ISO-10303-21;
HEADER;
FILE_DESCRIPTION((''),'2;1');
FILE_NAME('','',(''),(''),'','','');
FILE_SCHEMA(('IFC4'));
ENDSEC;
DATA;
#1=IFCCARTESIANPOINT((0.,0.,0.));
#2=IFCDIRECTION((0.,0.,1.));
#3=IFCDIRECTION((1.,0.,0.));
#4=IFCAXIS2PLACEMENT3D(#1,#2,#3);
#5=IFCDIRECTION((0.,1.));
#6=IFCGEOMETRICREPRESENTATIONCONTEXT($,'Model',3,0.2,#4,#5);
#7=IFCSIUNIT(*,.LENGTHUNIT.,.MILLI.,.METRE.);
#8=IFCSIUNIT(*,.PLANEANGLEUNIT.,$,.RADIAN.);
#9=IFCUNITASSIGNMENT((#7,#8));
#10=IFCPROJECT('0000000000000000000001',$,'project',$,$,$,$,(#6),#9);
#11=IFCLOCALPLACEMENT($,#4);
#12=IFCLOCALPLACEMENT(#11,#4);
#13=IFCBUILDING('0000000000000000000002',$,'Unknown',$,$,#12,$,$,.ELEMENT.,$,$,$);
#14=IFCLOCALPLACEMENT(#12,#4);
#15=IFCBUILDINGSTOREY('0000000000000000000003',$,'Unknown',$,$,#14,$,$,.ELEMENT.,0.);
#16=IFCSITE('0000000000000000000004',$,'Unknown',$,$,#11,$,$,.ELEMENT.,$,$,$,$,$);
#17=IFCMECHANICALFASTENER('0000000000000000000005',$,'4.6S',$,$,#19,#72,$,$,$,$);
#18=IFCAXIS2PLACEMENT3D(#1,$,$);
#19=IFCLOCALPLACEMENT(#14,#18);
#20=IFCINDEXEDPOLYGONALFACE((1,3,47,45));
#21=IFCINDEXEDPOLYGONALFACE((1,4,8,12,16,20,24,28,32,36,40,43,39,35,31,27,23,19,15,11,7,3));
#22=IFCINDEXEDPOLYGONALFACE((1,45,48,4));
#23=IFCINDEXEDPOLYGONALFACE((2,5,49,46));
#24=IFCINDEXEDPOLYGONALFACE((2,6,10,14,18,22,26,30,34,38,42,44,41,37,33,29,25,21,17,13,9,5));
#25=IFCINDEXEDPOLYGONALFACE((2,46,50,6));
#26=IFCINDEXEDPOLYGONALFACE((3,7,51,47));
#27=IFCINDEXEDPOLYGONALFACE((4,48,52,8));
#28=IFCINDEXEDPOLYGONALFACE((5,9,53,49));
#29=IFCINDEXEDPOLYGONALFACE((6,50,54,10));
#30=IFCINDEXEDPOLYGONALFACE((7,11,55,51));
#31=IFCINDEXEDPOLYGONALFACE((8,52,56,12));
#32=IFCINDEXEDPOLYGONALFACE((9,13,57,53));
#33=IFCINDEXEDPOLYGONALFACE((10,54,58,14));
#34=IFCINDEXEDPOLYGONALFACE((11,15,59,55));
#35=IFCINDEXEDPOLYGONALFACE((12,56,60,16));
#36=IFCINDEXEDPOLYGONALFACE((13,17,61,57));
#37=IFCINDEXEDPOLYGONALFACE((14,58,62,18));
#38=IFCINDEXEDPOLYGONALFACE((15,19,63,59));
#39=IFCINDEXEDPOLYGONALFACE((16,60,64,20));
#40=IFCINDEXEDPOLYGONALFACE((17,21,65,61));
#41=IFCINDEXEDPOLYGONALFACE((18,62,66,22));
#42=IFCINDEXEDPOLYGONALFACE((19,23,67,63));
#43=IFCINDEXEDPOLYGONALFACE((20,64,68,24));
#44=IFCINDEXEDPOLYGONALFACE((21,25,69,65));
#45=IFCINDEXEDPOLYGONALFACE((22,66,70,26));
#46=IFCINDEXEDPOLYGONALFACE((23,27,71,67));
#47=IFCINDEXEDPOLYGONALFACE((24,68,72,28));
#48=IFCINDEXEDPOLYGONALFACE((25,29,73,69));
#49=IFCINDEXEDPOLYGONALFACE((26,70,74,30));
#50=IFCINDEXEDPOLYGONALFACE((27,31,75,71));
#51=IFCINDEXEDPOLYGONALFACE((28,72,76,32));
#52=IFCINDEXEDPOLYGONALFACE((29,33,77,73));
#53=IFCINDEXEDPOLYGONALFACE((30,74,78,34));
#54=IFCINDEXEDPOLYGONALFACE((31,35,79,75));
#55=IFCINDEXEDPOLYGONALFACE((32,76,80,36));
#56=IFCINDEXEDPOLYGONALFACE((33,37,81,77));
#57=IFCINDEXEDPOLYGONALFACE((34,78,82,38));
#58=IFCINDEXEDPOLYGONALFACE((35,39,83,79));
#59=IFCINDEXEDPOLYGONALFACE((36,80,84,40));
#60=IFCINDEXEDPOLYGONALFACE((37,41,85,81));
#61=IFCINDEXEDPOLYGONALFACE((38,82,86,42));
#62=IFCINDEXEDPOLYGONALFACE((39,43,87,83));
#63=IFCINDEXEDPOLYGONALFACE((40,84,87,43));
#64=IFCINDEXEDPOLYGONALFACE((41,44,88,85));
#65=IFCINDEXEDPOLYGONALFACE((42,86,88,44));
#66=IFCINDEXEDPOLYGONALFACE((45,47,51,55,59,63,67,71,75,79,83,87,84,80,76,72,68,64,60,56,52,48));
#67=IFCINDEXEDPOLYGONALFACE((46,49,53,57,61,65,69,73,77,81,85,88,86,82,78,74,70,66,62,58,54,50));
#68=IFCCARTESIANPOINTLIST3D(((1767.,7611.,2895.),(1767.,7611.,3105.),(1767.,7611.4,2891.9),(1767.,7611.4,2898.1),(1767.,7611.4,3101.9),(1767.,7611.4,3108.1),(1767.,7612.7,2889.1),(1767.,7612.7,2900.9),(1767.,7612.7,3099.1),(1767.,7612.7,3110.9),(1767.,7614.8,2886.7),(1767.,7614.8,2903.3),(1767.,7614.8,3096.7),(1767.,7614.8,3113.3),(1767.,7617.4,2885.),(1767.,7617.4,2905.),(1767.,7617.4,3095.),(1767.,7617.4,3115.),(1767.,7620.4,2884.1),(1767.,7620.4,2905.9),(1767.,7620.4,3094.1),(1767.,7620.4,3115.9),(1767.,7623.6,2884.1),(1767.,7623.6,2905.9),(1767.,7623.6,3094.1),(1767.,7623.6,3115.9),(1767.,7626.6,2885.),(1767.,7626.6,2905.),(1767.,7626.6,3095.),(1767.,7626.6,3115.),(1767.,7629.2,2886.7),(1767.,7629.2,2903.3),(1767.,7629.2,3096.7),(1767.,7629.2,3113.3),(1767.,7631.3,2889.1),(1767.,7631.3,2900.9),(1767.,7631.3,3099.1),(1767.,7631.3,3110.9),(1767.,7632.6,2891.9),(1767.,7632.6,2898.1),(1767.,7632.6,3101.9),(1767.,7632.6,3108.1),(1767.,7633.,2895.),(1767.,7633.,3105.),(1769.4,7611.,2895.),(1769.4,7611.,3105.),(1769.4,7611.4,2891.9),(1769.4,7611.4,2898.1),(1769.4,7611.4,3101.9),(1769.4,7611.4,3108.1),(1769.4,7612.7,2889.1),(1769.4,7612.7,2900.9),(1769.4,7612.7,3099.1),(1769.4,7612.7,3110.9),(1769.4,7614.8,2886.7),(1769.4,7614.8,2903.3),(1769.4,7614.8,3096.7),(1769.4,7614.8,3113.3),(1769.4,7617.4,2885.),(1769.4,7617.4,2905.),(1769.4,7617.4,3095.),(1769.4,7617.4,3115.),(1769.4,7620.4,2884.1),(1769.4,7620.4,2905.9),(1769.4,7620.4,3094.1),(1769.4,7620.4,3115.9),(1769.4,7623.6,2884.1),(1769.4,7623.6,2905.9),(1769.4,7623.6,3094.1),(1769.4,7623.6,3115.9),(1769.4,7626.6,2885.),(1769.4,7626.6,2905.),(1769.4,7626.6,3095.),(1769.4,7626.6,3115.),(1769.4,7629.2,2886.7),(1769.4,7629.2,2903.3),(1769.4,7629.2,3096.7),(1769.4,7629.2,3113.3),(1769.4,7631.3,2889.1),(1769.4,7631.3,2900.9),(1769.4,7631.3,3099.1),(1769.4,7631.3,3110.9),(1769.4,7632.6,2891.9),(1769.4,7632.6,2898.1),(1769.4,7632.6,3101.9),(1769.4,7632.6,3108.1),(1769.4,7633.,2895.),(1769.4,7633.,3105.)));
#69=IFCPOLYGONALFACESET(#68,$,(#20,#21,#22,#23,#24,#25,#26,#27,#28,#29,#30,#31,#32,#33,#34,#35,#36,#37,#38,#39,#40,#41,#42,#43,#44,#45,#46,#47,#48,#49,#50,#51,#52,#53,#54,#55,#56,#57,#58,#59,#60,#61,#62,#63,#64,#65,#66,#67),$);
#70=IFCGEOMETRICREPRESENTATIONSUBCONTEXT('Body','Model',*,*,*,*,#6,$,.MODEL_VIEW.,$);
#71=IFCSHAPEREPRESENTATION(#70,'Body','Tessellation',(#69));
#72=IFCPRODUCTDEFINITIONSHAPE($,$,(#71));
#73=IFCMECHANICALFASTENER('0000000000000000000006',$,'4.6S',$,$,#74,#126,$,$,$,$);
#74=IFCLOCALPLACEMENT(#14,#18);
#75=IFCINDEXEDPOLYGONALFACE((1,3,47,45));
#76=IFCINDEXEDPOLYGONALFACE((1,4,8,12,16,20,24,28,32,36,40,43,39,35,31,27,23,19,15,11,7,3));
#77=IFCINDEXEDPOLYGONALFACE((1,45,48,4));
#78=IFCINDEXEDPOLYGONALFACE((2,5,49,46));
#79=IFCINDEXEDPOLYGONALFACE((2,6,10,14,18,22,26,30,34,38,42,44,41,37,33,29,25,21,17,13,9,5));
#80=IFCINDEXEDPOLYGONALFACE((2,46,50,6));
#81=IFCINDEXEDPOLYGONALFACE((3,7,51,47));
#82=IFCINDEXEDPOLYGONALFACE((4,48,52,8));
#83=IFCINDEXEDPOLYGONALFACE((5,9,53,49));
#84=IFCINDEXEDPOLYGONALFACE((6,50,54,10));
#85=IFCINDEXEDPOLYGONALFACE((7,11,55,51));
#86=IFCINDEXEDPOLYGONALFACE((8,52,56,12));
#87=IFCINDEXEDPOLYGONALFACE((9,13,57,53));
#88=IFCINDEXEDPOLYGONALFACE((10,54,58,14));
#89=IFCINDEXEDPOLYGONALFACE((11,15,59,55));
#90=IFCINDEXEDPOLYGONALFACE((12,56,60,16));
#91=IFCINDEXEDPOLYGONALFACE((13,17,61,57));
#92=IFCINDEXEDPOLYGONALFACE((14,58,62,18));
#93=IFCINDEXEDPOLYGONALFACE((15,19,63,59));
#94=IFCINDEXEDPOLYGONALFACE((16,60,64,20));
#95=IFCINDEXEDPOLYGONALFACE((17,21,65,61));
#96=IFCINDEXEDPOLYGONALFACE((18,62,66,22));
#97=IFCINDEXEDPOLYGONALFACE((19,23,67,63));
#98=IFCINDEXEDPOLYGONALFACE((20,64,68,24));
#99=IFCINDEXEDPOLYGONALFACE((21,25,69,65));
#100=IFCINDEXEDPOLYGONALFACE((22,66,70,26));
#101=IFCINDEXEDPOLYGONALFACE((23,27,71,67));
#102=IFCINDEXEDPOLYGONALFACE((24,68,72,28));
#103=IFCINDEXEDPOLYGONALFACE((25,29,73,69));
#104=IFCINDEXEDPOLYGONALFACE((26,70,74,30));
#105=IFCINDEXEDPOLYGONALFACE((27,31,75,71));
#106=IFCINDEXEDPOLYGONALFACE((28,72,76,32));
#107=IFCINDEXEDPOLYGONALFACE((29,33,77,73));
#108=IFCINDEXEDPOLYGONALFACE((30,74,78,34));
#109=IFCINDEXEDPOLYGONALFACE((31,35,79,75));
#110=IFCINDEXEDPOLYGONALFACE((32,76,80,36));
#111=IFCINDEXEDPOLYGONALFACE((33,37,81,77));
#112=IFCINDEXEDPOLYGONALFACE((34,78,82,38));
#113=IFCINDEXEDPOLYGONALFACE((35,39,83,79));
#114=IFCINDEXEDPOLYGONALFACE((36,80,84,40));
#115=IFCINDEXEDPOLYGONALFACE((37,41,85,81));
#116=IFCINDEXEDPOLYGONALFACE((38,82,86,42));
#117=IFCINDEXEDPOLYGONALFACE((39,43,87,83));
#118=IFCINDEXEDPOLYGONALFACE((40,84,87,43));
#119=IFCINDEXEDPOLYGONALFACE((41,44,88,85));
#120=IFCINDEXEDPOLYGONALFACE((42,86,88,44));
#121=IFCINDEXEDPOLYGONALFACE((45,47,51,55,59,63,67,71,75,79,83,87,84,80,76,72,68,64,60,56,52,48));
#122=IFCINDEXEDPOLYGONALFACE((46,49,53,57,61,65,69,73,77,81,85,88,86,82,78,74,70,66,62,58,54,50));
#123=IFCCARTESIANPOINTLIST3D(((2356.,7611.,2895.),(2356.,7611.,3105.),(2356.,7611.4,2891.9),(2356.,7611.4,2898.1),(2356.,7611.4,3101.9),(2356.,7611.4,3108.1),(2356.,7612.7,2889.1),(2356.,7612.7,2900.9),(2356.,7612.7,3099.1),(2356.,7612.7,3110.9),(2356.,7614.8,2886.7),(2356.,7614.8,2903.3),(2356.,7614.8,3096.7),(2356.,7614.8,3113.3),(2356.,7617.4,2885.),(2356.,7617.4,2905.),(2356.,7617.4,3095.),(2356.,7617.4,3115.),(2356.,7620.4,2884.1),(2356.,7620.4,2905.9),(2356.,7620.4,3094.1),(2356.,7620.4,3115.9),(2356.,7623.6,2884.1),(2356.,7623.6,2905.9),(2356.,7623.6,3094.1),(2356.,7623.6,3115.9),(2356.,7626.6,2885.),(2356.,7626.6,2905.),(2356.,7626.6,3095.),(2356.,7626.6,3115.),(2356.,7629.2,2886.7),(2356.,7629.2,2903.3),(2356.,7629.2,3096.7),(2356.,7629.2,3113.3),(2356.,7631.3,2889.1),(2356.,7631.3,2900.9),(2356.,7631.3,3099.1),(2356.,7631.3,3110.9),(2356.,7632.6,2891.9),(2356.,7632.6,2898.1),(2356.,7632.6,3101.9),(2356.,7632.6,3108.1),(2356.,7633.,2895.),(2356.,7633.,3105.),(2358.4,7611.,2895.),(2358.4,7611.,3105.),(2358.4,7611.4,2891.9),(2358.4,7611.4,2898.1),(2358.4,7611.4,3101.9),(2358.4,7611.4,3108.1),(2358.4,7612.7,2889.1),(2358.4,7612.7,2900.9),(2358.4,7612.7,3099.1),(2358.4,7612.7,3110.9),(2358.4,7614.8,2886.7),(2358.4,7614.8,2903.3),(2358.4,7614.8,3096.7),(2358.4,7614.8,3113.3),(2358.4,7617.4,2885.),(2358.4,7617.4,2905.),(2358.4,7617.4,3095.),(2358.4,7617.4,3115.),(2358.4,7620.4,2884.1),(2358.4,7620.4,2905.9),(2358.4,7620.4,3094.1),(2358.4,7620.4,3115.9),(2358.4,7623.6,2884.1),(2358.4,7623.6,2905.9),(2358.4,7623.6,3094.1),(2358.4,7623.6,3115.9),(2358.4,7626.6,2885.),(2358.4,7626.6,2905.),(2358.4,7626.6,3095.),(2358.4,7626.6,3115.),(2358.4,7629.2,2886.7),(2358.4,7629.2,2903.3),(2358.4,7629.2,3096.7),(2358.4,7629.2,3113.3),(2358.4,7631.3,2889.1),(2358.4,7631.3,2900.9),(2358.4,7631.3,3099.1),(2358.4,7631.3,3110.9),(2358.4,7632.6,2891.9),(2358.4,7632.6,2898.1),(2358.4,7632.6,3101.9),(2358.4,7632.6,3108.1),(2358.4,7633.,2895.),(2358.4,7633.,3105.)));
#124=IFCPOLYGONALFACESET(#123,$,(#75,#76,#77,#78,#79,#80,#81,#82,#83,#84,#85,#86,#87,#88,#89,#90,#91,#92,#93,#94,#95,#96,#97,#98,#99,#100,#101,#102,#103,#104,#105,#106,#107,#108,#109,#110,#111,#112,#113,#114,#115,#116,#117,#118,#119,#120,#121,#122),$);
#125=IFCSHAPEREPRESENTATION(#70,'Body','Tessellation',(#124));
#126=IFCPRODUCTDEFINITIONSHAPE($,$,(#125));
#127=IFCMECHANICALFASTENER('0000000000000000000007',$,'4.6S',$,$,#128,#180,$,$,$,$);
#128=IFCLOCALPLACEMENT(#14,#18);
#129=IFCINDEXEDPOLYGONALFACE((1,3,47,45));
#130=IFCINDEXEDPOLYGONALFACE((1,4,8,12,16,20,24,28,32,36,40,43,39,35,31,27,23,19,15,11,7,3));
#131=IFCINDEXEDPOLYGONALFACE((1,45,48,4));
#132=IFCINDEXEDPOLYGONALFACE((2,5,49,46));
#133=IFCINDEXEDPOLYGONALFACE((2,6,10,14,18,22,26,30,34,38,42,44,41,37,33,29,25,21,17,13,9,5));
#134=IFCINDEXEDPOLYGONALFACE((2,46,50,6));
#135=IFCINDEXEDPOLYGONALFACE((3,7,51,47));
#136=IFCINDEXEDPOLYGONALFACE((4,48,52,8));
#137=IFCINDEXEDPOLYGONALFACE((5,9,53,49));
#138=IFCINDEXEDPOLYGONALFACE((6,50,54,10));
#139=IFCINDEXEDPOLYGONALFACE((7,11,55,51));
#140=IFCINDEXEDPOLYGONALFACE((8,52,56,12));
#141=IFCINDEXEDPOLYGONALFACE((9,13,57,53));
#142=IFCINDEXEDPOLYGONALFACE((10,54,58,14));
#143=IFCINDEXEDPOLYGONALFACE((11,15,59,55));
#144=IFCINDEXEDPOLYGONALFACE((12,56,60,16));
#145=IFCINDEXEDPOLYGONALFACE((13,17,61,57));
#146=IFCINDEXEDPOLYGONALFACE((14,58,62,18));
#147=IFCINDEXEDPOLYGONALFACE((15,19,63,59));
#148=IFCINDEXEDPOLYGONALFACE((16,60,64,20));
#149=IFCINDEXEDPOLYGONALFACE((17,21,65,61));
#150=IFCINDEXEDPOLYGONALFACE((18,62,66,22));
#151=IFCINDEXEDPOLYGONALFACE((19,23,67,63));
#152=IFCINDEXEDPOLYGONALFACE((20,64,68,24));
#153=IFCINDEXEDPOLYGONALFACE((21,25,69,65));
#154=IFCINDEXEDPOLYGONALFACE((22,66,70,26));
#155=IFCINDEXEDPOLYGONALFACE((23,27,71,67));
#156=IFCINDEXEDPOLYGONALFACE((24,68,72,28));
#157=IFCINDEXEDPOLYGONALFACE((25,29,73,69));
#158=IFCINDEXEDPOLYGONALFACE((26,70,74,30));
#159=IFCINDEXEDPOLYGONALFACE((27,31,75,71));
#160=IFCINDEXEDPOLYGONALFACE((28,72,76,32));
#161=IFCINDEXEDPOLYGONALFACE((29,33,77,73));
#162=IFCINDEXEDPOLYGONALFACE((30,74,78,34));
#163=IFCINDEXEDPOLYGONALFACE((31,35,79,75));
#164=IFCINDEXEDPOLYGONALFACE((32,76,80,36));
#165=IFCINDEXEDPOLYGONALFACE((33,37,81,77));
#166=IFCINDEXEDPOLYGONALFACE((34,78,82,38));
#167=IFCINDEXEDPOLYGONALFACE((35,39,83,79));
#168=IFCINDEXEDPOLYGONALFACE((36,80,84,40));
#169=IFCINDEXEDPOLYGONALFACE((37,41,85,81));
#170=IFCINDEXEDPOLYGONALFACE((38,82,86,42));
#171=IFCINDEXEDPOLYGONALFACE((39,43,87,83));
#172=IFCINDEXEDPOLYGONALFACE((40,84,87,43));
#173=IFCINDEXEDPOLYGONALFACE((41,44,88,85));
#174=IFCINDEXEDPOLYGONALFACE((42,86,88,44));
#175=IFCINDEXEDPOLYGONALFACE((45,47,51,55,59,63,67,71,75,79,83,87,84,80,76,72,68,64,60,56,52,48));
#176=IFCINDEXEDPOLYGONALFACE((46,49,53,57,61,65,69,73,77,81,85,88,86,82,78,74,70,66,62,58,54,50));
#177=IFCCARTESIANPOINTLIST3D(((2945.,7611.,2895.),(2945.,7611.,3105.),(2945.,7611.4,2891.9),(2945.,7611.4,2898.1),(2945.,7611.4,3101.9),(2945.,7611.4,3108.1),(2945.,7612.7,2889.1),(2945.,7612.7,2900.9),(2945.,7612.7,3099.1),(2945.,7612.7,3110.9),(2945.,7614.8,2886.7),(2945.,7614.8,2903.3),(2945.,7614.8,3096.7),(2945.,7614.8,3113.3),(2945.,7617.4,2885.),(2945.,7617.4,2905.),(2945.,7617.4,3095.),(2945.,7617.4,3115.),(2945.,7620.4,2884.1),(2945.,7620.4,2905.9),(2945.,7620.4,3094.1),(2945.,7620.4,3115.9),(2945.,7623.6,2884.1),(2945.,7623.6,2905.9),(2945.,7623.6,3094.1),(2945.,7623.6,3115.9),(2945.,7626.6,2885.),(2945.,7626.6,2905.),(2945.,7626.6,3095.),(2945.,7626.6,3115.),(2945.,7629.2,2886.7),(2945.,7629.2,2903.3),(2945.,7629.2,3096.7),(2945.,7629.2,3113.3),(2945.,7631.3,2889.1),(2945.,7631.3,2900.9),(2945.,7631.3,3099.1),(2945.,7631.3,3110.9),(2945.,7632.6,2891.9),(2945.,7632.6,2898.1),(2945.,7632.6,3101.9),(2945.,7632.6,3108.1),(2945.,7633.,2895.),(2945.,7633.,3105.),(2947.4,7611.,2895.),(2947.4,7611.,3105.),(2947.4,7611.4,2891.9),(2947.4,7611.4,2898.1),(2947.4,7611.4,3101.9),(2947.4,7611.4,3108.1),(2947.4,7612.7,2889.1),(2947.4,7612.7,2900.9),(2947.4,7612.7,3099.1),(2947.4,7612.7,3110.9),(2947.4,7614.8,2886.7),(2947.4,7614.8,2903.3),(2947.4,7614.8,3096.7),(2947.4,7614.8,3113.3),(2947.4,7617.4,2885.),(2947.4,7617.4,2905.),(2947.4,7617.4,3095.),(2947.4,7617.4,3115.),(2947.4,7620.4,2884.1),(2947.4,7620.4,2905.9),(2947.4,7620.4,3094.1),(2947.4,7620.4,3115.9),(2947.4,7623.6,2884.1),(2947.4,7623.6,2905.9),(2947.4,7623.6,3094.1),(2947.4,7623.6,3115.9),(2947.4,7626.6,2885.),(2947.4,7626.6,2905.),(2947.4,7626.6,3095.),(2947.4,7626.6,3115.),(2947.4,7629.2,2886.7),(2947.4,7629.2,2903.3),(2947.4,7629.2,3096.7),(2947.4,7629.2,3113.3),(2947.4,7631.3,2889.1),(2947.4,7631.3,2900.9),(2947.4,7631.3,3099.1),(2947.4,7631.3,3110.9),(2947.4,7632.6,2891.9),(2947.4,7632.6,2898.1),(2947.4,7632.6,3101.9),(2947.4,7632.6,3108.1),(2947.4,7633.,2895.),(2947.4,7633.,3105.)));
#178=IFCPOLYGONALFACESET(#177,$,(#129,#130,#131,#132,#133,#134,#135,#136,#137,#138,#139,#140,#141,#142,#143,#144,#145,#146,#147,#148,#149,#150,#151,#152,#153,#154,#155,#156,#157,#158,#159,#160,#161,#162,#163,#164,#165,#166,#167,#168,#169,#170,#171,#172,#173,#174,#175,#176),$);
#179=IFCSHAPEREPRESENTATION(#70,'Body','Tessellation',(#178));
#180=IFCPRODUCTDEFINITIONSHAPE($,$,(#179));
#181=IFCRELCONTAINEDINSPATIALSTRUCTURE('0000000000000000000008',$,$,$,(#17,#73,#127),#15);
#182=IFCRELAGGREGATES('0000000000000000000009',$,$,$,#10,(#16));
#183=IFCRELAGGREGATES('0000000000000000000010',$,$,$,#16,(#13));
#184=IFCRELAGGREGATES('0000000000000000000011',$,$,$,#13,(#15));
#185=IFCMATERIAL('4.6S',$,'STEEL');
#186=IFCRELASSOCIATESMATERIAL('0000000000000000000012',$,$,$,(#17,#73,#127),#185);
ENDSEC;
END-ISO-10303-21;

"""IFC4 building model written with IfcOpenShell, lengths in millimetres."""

from ifc_helpers import new_model, si_unit, direction, frame, origin_with_axes, place, context, subcontext, project, spatial, arc, indexed_curve, outline, extrude, source, transform, mapped, material, element, save


model = new_model("IFC4")

# Units and contexts
model_context = context("Model", 3, precision=0.2, world=origin_with_axes(), true_north=direction((0.0, 1.0)))
body_context = subcontext(model_context, "Body", "Model", "MODEL_VIEW")
ifc_project = project(units=[si_unit("LENGTHUNIT", "METRE", prefix="MILLI"), si_unit("PLANEANGLEUNIT", "RADIAN")], contexts=[model_context])

# Site, building, storey
site_placement = place(None, origin_with_axes())
site = spatial("IfcSite", under=ifc_project, at=site_placement, Name="Unknown", CompositionType="ELEMENT")
building_placement = place(site_placement, origin_with_axes())
building = spatial("IfcBuilding", under=site, at=building_placement, Name="Unknown", CompositionType="ELEMENT")
storey_placement = place(building_placement, origin_with_axes())
storey = spatial("IfcBuildingStorey", under=building, at=storey_placement, Name="Unknown", CompositionType="ELEMENT", Elevation=0.0)

# Mechanical fasteners
ifc_material_1 = material(Name="4.6S", Category="STEEL")
shared_shape_1 = source(origin_with_axes(), body_context, "Body", "SweptSolid", [
    extrude(outline(indexed_curve([(11.0, 0.0), (0.0, 11.0), (-11.0, 0.0), (0.0, -11.0)], segments=[arc(1, 2, 3), arc(3, 4, 1)])), frame((0.0, 0.0, 1.2), z_axis=(0.0, 0.0, -1.0), x_axis=(0.0, 1.0, 0.0)), (0.0, 0.0, 1.0), 2.4),
])
for number, where, z_axis, x_axis, name in (
    (1, (1768.2, 7622.0, 2895.0), (-1.0, 0.0, 0.0), (0.0, 0.0, 1.0), "4.6S"),
    (2, (2357.2, 7622.0, 2895.0), (-1.0, 0.0, 0.0), (0.0, 0.0, 1.0), "4.6S"),
    (3, (2946.2, 7622.0, 2895.0), (-1.0, 0.0, 0.0), (0.0, 0.0, 1.0), "4.6S"),
):
    element("IfcMechanicalFastener", number, at=place(storey_placement, frame(where, z_axis=z_axis, x_axis=x_axis)), inside=storey, material=ifc_material_1, Name=name, context=body_context, shape_type="MappedRepresentation", body=[
        mapped(shared_shape_1, transform((0.0, 0.0, 0.0))),
        mapped(shared_shape_1, transform((210.0, 0.0, 0.0))),
    ])

save(model, "model.ifc")
